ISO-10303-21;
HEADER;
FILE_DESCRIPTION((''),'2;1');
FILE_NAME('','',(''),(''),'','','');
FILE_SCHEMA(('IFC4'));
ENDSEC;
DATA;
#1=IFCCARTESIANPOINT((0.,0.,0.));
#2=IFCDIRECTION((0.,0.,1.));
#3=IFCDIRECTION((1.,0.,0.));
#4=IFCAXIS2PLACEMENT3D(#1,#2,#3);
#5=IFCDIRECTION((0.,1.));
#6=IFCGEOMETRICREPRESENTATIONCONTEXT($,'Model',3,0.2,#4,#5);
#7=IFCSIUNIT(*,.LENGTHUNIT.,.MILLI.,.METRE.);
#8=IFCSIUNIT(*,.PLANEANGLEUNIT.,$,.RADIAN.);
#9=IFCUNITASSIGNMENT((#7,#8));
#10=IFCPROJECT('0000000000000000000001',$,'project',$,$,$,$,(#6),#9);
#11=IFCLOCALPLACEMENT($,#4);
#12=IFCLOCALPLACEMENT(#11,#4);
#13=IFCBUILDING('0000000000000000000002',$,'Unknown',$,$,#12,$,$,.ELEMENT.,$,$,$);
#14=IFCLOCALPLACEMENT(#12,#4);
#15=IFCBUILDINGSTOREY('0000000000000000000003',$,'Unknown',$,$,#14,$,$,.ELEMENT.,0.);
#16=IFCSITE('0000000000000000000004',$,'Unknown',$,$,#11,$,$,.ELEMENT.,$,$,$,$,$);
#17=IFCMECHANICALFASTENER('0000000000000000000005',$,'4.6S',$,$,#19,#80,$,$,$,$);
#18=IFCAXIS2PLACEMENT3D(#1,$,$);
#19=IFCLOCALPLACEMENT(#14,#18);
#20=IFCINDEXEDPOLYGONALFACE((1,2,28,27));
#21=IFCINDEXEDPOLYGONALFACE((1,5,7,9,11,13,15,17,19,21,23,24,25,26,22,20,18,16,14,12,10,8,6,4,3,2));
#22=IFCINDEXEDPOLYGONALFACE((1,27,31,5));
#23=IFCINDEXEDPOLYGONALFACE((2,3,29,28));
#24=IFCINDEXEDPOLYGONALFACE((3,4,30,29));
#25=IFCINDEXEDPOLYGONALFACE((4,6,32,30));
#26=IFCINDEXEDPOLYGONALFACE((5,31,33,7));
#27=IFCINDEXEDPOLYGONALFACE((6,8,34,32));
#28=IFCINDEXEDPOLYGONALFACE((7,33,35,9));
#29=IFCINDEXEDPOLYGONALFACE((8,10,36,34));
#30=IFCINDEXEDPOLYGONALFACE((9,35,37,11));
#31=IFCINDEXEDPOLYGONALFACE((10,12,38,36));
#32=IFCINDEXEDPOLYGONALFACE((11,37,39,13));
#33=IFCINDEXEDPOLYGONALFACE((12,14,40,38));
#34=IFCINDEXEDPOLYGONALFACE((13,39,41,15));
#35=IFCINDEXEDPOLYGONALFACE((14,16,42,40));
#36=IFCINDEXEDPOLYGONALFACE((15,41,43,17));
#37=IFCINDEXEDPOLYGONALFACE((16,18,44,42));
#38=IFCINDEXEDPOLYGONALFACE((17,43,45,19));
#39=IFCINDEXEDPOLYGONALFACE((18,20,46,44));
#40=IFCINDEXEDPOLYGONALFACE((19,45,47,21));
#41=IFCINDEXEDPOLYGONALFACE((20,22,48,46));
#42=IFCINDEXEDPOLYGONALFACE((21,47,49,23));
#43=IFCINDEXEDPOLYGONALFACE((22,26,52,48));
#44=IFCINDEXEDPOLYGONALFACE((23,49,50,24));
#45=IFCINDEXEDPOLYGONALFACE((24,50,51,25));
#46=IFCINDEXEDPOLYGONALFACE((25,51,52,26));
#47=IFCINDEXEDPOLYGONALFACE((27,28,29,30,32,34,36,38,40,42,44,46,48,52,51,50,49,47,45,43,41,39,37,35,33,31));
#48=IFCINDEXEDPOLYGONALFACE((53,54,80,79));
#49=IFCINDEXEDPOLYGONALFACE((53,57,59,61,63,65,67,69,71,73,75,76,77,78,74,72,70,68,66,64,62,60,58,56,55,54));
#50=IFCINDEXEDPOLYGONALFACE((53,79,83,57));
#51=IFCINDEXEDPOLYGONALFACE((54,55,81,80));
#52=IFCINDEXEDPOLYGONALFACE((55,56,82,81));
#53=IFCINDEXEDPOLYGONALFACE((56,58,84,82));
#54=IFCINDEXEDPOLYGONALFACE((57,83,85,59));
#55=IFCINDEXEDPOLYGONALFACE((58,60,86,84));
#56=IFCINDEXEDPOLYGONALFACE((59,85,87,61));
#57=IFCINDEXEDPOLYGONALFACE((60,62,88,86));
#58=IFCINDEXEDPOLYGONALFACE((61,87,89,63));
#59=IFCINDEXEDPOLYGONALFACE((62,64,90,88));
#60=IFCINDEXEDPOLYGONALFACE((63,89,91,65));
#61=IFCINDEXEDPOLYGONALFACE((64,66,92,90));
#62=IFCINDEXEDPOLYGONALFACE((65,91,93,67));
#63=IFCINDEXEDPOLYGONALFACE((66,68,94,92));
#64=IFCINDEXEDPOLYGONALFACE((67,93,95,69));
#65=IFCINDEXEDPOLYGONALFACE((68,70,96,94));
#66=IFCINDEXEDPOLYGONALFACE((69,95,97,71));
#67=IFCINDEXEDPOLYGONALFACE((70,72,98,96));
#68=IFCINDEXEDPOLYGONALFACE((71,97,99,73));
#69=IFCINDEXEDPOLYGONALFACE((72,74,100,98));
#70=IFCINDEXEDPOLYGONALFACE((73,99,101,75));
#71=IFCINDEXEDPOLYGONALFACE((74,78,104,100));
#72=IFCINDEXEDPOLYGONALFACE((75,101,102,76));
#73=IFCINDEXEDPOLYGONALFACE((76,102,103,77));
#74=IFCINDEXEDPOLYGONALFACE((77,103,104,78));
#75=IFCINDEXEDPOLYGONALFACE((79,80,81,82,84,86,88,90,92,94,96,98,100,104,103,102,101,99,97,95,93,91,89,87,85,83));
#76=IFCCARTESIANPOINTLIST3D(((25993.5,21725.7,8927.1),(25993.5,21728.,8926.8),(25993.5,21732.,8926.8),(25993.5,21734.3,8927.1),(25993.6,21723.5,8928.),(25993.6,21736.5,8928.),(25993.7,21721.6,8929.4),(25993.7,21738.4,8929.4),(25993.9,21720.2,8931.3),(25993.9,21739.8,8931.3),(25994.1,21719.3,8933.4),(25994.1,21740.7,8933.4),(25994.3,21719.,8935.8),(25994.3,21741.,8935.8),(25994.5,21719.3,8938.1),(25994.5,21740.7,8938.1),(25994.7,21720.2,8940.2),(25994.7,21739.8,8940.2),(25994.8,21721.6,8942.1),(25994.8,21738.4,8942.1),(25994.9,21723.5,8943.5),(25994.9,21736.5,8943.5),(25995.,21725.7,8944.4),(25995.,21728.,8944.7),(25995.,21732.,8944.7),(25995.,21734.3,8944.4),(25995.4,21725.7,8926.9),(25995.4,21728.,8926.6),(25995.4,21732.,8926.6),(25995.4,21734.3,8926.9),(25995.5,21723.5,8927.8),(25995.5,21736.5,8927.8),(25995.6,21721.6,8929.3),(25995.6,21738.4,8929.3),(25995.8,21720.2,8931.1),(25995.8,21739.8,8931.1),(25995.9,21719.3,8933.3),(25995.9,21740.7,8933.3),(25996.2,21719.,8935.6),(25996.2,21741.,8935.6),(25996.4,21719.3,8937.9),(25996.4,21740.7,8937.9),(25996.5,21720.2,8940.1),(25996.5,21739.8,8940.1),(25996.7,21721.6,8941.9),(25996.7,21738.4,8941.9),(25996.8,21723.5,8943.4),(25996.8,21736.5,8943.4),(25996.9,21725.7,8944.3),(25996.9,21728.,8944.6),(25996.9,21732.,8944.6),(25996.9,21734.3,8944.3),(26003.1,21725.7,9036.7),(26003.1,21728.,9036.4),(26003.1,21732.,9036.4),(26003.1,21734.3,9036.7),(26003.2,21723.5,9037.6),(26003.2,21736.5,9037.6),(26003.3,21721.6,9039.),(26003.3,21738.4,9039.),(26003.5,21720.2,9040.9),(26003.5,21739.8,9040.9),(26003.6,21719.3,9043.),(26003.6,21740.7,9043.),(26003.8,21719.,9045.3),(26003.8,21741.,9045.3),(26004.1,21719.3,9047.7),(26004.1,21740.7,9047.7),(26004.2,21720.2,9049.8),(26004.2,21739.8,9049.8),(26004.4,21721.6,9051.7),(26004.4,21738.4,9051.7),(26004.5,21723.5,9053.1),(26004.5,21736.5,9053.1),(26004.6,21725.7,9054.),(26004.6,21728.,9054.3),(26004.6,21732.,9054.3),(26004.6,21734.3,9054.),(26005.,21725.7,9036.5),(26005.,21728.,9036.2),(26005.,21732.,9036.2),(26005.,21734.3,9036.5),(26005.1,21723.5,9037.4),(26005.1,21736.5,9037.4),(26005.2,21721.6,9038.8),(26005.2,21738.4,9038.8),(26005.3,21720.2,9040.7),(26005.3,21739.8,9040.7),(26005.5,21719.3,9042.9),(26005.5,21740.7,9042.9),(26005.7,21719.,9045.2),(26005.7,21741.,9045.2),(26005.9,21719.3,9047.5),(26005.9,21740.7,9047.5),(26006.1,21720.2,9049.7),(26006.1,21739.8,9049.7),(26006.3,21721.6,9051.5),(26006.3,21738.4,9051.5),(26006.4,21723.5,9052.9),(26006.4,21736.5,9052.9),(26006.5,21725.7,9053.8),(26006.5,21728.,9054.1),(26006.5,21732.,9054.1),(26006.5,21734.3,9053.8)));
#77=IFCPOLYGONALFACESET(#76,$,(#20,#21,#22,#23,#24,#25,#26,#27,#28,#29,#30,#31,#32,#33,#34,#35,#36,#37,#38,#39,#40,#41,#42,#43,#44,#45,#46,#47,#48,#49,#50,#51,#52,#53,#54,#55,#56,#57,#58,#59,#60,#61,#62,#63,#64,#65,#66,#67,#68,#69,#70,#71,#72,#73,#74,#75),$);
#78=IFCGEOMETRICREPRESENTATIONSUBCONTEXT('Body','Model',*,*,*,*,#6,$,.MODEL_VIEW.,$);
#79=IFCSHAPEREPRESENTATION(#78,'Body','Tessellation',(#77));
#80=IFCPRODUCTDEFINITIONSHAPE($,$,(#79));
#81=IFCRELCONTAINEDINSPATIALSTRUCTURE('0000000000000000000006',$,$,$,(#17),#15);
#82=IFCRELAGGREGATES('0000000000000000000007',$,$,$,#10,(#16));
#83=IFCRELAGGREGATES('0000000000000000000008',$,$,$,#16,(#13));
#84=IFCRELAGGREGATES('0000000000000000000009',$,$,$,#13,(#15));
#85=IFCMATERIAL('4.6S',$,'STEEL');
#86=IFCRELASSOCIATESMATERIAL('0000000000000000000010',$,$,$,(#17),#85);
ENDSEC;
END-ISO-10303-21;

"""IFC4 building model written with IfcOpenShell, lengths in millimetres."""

from ifc_helpers import new_model, si_unit, direction, frame, origin_with_axes, place, context, subcontext, project, spatial, line, arc, indexed_curve, outline, extrude, source, transform, mapped, material, element, save


model = new_model("IFC4")

# Units and contexts
model_context = context("Model", 3, precision=0.2, world=origin_with_axes(), true_north=direction((0.0, 1.0)))
body_context = subcontext(model_context, "Body", "Model", "MODEL_VIEW")
ifc_project = project(units=[si_unit("LENGTHUNIT", "METRE", prefix="MILLI"), si_unit("PLANEANGLEUNIT", "RADIAN")], contexts=[model_context])

# Site, building, storey
site_placement = place(None, origin_with_axes())
site = spatial("IfcSite", under=ifc_project, at=site_placement, Name="Unknown", CompositionType="ELEMENT")
building_placement = place(site_placement, origin_with_axes())
building = spatial("IfcBuilding", under=site, at=building_placement, Name="Unknown", CompositionType="ELEMENT")
storey_placement = place(building_placement, origin_with_axes())
storey = spatial("IfcBuildingStorey", under=building, at=storey_placement, Name="Unknown", CompositionType="ELEMENT", Elevation=0.0)

# Mechanical fastener
ifc_material_1 = material(Name="4.6S", Category="STEEL")
shared_shape_1 = source(origin_with_axes(), body_context, "Body", "SweptSolid", [
    extrude(outline(indexed_curve([(-2.0, 9.0), (2.0, 9.0), (2.0, 9.0), (8.4, 6.4), (11.0, 0.0), (8.4, -6.4), (2.0, -9.0), (-2.0, -9.0), (-2.8, -9.0), (-11.0, 0.0), (-8.4, 6.4)], segments=[line(1, 2, 3), arc(3, 4, 5), arc(5, 6, 7), line(7, 8), arc(8, 9, 10), arc(10, 11, 1)])), frame((0.0, 0.0, 0.9), z_axis=(0.0, 0.0, -1.0), x_axis=(0.0, 1.0, 0.0)), (0.0, 0.0, 1.0), 1.9),
])
mechanical_fastener_1_placement = place(storey_placement, frame((25995.2, 21730.0, 8935.7), z_axis=(-0.996195, 0.0, 0.087156), x_axis=(0.087156, 0.0, 0.996195)))
element("IfcMechanicalFastener", 1, at=mechanical_fastener_1_placement, inside=storey, material=ifc_material_1, Name="4.6S", context=body_context, shape_type="MappedRepresentation", body=[
    mapped(shared_shape_1, transform((0.0, 0.0, 0.0))),
    mapped(shared_shape_1, transform((110.0, 0.0, 0.0))),
])

save(model, "model.ifc")
